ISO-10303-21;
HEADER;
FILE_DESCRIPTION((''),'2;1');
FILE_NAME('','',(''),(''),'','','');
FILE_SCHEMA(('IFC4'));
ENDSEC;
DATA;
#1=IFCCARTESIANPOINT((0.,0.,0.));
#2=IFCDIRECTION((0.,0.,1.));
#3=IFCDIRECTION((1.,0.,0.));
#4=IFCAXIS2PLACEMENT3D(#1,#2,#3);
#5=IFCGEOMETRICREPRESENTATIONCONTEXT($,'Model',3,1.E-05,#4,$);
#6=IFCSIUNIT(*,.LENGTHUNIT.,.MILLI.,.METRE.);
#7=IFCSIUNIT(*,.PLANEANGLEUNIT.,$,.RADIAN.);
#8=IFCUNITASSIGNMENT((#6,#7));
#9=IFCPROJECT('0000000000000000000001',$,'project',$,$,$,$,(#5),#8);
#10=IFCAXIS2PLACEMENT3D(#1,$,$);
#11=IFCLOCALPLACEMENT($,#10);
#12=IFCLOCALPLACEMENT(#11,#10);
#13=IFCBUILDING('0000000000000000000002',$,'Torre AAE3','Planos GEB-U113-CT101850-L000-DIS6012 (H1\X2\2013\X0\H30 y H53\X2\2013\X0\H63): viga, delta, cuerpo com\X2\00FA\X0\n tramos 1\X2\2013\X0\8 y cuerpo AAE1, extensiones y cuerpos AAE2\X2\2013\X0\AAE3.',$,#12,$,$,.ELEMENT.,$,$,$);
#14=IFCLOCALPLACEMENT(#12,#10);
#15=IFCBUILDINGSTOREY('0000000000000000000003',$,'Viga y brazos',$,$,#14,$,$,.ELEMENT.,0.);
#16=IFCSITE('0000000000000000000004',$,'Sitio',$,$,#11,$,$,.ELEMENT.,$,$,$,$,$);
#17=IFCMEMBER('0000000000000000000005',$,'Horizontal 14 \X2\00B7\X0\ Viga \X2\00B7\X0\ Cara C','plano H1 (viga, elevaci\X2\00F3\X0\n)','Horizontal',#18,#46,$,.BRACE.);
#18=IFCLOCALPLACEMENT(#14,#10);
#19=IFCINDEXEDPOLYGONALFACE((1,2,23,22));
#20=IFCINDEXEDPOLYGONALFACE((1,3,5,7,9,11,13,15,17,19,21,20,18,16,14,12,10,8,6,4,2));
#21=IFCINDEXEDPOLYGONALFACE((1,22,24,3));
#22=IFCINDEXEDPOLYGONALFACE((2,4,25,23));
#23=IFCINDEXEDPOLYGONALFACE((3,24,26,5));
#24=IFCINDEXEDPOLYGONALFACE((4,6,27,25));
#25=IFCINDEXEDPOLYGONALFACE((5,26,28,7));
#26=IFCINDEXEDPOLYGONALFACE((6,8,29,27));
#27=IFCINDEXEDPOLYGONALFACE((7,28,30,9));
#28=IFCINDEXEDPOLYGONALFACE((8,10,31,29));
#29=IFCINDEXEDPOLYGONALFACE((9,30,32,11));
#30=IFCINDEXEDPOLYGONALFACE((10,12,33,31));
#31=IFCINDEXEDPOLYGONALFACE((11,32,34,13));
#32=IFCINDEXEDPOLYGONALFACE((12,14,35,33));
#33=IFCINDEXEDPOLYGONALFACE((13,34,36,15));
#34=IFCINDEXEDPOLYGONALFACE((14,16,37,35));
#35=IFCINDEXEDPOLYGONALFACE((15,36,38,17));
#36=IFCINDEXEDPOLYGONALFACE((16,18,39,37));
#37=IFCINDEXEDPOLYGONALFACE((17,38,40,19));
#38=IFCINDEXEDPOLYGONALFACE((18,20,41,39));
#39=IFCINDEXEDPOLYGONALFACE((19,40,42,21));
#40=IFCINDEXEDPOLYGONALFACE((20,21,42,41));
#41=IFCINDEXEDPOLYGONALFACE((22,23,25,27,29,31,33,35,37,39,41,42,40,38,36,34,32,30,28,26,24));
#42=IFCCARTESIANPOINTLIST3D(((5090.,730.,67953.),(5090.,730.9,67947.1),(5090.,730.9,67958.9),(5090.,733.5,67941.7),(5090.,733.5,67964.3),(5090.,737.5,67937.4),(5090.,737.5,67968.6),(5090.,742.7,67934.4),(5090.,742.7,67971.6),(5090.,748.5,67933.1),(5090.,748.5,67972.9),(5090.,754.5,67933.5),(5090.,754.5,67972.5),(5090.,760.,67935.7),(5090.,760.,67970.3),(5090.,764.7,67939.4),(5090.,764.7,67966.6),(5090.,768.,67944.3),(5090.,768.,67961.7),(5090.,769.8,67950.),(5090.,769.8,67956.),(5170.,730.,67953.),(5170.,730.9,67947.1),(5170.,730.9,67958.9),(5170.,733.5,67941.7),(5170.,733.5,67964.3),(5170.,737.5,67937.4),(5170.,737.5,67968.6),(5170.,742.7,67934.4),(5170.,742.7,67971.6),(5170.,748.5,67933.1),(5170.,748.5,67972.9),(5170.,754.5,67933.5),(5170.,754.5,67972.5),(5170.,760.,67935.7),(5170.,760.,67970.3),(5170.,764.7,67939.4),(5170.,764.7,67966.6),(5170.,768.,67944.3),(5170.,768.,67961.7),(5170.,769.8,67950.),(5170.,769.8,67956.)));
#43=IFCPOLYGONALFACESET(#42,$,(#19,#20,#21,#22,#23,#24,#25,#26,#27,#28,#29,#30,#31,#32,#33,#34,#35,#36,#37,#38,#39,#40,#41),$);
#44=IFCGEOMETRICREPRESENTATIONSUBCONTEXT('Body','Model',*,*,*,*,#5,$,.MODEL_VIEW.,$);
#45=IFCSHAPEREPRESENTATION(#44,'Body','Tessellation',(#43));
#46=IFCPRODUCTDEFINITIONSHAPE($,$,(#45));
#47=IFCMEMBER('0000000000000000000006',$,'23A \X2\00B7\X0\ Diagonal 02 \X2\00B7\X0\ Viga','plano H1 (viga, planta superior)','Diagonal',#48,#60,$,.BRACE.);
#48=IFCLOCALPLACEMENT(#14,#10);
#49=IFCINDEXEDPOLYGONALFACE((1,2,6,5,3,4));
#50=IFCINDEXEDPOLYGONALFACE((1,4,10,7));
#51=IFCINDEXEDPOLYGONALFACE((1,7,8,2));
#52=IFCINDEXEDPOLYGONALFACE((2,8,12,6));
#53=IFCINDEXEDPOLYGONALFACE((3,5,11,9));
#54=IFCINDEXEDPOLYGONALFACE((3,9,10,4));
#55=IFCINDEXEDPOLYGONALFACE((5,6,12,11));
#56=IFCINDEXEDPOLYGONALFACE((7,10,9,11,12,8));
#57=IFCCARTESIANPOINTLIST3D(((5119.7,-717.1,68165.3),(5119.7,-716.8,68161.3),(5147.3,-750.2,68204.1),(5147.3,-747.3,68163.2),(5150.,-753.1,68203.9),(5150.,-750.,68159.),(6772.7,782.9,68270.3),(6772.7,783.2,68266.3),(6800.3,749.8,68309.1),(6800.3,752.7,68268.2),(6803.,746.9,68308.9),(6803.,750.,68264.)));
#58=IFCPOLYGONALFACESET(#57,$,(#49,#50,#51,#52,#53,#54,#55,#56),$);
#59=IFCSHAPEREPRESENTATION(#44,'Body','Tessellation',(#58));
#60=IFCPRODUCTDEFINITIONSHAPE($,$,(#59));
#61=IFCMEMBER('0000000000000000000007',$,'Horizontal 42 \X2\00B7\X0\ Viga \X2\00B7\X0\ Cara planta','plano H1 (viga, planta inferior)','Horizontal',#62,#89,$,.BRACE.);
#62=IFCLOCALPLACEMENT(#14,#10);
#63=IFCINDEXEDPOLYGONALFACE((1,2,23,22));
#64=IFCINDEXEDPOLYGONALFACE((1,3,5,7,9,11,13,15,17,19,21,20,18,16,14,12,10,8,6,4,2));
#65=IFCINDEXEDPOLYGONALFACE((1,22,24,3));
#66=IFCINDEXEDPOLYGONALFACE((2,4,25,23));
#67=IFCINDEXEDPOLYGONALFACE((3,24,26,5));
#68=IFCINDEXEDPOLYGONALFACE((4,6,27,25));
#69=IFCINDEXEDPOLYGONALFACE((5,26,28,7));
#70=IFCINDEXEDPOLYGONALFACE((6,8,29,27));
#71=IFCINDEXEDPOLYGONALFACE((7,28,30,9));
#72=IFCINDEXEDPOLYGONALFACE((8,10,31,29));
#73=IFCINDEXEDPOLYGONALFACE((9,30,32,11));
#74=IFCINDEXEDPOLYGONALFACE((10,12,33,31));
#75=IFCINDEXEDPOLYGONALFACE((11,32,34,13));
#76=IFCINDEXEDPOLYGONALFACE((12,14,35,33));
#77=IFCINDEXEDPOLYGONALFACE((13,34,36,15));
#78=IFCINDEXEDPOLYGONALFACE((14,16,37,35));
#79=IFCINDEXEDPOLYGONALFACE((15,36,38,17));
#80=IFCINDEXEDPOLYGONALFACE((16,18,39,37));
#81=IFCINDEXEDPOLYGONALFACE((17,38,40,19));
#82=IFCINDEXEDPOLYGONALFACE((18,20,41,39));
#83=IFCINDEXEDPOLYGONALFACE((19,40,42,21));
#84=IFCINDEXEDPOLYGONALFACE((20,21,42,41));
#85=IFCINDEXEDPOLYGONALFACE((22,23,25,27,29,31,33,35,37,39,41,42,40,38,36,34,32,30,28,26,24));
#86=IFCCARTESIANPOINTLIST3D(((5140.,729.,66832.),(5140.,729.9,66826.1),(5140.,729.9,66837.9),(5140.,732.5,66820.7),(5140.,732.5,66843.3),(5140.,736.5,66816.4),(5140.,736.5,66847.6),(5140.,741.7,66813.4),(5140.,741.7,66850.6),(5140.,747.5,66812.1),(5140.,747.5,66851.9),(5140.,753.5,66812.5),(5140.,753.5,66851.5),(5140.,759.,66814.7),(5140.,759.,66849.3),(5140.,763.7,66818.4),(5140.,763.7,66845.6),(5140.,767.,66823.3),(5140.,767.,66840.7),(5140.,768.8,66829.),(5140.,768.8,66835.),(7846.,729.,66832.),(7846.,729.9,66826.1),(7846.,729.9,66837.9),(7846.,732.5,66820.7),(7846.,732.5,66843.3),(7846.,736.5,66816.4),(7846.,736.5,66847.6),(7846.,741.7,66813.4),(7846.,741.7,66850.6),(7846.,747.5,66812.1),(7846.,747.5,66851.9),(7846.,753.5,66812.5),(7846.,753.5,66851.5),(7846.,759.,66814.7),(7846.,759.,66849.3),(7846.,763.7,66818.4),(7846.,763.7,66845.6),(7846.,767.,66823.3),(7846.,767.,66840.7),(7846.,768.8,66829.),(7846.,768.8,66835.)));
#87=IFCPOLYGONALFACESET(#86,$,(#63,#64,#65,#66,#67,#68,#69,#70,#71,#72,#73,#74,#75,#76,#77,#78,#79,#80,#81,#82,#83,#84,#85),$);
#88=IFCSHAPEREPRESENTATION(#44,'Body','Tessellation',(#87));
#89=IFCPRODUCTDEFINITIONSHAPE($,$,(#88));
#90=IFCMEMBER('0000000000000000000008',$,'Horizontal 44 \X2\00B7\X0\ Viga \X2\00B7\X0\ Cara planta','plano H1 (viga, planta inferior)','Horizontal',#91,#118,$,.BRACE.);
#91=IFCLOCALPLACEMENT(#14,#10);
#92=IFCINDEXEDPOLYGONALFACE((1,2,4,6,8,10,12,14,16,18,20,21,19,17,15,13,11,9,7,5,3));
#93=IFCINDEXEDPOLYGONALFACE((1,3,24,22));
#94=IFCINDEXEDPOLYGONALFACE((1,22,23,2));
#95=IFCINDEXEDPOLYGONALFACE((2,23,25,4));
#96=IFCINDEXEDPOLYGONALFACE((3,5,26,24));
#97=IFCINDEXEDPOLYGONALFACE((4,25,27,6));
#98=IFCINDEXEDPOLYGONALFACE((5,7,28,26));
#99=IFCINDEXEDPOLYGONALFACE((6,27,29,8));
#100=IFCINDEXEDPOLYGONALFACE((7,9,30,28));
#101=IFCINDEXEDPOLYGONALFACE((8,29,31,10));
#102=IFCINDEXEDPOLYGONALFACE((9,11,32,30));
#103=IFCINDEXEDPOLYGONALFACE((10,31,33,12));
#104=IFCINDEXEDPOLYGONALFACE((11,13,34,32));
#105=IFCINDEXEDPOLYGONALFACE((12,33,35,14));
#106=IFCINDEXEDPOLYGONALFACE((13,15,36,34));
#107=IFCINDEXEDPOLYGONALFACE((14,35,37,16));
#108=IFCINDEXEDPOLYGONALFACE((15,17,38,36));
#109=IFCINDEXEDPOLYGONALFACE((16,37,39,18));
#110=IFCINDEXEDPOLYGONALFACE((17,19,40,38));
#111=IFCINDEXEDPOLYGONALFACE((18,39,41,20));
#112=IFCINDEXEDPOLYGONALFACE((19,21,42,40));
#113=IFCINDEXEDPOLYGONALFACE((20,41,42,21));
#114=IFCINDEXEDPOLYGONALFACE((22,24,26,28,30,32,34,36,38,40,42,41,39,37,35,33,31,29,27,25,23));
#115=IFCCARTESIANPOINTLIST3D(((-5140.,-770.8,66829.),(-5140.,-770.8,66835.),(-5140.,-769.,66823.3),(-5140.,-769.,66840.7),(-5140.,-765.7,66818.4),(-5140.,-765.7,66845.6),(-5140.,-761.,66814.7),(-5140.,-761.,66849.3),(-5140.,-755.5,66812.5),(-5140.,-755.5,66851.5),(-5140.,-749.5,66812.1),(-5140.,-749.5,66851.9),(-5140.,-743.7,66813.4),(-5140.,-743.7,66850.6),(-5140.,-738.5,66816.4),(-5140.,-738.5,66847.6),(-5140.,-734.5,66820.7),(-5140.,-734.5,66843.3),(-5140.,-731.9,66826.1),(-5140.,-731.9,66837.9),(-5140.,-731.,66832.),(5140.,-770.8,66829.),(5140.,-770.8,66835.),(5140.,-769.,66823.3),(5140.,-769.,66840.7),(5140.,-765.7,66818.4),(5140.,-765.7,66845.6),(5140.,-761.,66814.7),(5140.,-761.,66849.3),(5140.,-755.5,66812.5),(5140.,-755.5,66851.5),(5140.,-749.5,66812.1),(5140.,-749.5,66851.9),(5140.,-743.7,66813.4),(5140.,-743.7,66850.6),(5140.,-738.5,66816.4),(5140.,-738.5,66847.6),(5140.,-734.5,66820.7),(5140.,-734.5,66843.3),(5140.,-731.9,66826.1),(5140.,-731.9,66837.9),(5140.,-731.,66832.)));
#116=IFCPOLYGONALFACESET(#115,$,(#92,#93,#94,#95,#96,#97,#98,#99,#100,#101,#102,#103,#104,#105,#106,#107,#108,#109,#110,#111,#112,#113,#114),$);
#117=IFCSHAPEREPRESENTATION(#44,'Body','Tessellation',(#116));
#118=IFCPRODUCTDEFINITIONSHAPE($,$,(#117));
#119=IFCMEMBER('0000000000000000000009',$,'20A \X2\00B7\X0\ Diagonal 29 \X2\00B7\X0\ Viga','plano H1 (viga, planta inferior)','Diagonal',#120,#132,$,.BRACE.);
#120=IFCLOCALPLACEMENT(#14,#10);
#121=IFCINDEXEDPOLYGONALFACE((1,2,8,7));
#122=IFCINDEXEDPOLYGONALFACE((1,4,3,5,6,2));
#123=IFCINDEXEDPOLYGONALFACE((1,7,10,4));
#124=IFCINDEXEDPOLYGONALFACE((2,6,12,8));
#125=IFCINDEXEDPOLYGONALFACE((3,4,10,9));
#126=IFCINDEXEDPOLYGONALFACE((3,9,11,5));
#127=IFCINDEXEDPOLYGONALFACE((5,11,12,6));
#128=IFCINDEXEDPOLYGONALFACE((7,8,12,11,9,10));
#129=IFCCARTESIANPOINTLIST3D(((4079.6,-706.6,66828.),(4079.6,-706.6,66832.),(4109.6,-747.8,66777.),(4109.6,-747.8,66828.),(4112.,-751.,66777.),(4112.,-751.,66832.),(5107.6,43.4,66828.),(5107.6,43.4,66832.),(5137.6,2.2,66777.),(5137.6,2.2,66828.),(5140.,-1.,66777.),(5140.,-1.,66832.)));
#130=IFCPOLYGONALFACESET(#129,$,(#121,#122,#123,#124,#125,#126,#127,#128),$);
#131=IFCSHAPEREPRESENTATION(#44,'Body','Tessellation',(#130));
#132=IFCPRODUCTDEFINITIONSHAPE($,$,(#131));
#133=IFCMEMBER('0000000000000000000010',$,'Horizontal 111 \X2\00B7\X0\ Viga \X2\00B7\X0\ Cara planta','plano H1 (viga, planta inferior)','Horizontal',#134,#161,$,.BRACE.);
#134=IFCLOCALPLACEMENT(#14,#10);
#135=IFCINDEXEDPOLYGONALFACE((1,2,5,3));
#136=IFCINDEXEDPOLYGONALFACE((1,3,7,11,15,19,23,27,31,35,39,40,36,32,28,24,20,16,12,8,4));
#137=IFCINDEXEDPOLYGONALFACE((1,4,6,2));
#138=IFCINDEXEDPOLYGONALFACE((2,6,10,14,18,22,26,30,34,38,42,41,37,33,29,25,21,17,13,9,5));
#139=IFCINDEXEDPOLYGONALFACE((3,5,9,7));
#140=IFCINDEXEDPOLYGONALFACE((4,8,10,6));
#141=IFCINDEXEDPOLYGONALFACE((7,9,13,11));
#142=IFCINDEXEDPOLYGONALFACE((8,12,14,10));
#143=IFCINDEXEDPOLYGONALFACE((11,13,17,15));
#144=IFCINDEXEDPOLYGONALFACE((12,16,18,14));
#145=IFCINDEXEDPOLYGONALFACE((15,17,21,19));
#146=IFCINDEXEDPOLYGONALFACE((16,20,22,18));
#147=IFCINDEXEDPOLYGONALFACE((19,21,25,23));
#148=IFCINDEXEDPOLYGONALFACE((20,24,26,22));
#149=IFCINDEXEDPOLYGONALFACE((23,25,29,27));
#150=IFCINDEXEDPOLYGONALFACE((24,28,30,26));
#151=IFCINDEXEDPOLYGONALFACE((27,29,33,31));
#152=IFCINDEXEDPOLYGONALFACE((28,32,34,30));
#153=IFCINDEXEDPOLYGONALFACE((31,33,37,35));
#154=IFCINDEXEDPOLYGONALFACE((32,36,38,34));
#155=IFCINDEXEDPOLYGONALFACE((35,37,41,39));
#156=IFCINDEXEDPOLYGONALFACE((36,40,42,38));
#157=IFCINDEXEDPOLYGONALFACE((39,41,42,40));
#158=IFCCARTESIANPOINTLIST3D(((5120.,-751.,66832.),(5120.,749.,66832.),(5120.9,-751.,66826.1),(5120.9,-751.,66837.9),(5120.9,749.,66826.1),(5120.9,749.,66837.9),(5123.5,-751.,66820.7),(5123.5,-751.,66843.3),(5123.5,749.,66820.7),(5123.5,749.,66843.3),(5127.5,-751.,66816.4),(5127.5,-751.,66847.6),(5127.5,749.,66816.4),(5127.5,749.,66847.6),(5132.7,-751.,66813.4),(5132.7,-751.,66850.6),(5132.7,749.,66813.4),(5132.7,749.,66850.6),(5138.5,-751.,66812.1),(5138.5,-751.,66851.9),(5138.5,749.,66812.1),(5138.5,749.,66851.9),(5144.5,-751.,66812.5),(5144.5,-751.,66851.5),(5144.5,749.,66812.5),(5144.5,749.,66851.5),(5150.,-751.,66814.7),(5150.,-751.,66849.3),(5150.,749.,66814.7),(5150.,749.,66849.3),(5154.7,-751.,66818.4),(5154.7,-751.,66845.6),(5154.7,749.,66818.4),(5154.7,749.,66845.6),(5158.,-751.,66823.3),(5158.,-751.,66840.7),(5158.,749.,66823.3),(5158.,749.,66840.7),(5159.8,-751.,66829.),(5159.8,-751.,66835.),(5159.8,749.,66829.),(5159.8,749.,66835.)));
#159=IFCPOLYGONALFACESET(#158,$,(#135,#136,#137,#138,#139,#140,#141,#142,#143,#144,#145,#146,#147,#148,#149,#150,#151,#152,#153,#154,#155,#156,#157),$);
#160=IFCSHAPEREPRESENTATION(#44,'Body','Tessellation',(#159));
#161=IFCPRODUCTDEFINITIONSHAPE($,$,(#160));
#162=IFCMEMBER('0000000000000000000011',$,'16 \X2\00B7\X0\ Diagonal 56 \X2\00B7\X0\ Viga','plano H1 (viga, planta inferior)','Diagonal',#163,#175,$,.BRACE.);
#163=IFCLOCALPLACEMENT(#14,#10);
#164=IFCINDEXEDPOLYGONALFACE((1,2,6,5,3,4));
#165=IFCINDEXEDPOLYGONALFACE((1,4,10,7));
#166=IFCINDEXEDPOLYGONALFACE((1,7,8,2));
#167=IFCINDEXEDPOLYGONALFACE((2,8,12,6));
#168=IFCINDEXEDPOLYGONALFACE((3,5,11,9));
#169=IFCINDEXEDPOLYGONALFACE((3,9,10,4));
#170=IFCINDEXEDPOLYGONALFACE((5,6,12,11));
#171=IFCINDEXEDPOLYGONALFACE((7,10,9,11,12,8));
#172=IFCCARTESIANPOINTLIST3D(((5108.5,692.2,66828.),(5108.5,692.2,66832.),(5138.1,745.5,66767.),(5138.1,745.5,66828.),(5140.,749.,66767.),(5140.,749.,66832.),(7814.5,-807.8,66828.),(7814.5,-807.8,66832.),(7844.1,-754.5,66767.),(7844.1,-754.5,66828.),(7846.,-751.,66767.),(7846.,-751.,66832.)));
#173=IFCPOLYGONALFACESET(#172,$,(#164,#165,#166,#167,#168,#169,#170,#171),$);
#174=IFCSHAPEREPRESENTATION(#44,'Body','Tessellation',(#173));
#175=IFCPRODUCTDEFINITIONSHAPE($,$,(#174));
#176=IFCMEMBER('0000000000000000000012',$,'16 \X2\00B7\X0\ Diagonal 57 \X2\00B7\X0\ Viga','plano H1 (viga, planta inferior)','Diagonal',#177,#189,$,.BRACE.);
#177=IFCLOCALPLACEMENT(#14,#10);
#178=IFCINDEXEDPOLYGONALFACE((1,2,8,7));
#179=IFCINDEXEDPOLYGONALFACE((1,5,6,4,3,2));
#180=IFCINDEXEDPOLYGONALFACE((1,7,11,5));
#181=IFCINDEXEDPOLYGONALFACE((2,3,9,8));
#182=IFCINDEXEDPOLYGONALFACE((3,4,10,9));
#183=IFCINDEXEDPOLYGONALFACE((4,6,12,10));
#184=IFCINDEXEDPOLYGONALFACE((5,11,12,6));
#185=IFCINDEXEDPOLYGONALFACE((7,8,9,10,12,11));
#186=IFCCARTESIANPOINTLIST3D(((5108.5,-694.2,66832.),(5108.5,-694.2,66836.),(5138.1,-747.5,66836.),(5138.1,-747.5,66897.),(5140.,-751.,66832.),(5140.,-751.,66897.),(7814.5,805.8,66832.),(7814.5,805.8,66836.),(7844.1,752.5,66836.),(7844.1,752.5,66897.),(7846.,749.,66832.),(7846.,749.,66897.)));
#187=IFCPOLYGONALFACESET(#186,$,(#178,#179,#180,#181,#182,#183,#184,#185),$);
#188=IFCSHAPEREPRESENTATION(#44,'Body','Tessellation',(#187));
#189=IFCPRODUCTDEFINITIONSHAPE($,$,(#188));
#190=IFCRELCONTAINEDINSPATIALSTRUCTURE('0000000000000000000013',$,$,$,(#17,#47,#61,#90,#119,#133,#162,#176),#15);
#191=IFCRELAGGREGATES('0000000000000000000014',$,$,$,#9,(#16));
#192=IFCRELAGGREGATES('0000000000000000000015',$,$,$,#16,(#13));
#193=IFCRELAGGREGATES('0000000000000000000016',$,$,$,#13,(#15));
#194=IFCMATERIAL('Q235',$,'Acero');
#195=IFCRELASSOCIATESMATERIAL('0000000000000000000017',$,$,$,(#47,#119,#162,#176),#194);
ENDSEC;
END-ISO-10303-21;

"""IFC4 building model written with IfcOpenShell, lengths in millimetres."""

from ifc_helpers import new_model, si_unit, frame, frame_2d, origin, origin_with_axes, place, context, subcontext, project, spatial, circle, l_section, extrude, material, element, save


model = new_model("IFC4")

# Units and contexts
model_context = context("Model", 3, precision=1e-05, world=origin_with_axes())
body_context = subcontext(model_context, "Body", "Model", "MODEL_VIEW")
ifc_project = project(units=[si_unit("LENGTHUNIT", "METRE", prefix="MILLI"), si_unit("PLANEANGLEUNIT", "RADIAN")], contexts=[model_context])

# Site, building, storey
site_placement = place(None, origin())
site = spatial("IfcSite", under=ifc_project, at=site_placement, Name="Sitio", CompositionType="ELEMENT")
building_placement = place(site_placement, origin())
building = spatial("IfcBuilding", under=site, at=building_placement, Name="Torre AAE3", Description="Planos GEB-U113-CT101850-L000-DIS6012 (H1–H30 y H53–H63): viga, delta, cuerpo común tramos 1–8 y cuerpo AAE1, extensiones y cuerpos AAE2–AAE3.", CompositionType="ELEMENT")
storey_placement = place(building_placement, origin())
storey = spatial("IfcBuildingStorey", under=building, at=storey_placement, Name="Viga y brazos", CompositionType="ELEMENT", Elevation=0.0)

# Members
for number, where, z_axis, x_axis, name in (
    (1, (5090.0, 750.0, 67953.0), (1.0, 0.0, 0.0), (0.0, -1.0, 0.0), "Horizontal 14 · Viga · Cara C"),
):
    element("IfcMember", number, at=place(storey_placement, frame(where, z_axis=z_axis, x_axis=x_axis)), inside=storey, Name=name, Description="plano H1 (viga, elevación)", ObjectType="Horizontal", PredefinedType="BRACE", context=body_context, shape_type="SweptSolid", body=[
        extrude(circle(Radius=20.0), None, (0.0, 0.0, 1.0), 80.0),
    ])
ifc_material = material(Name="Q235", Category="Acero")
member_1_placement = place(storey_placement, frame((5150.0, -750.0, 68159.0), z_axis=(0.73973, 0.671261, 0.046988), x_axis=(-0.672904, 0.737924, 0.051655)))
element("IfcMember", 2, at=member_1_placement, inside=storey, material=ifc_material, Name="23A · Diagonal 02 · Viga", Description="plano H1 (viga, planta superior)", ObjectType="Diagonal", PredefinedType="BRACE", context=body_context, shape_type="SweptSolid", body=[
    extrude(l_section(Depth=45.0, Width=45.0, Thickness=4.0, at=frame_2d((22.5, 22.5))), None, (0.0, 0.0, 1.0), 2234.6),
])
member_2_placement = place(storey_placement, frame((5140.0, 749.0, 66832.0), z_axis=(1.0, 0.0, 0.0), x_axis=(0.0, -1.0, 0.0)))
element("IfcMember", 3, at=member_2_placement, inside=storey, Name="Horizontal 42 · Viga · Cara planta", Description="plano H1 (viga, planta inferior)", ObjectType="Horizontal", PredefinedType="BRACE", context=body_context, shape_type="SweptSolid", body=[
    extrude(circle(Radius=20.0), None, (0.0, 0.0, 1.0), 2706.0),
])
member_3_placement = place(storey_placement, frame((5140.0, -751.0, 66832.0), z_axis=(-1.0, 0.0, 0.0), x_axis=(0.0, 1.0, 0.0)))
element("IfcMember", 4, at=member_3_placement, inside=storey, Name="Horizontal 44 · Viga · Cara planta", Description="plano H1 (viga, planta inferior)", ObjectType="Horizontal", PredefinedType="BRACE", context=body_context, shape_type="SweptSolid", body=[
    extrude(circle(Radius=20.0), None, (0.0, 0.0, 1.0), 10280.0),
])
member_4_placement = place(storey_placement, frame((5140.0, -1.0, 66832.0), z_axis=(-0.807852, -0.589386, 0.0), x_axis=(-0.589386, 0.807852, 0.0)))
element("IfcMember", 5, at=member_4_placement, inside=storey, material=ifc_material, Name="20A · Diagonal 29 · Viga", Description="plano H1 (viga, planta inferior)", ObjectType="Diagonal", PredefinedType="BRACE", context=body_context, shape_type="SweptSolid", body=[
    extrude(l_section(Depth=55.0, Width=55.0, Thickness=4.0, at=frame_2d((27.5, 27.5))), None, (0.0, 0.0, 1.0), 1272.5),
])
member_5_placement = place(storey_placement, frame((5140.0, 749.0, 66832.0), z_axis=(0.0, -1.0, 0.0), x_axis=(-1.0, 0.0, 0.0)))
element("IfcMember", 6, at=member_5_placement, inside=storey, Name="Horizontal 111 · Viga · Cara planta", Description="plano H1 (viga, planta inferior)", ObjectType="Horizontal", PredefinedType="BRACE", context=body_context, shape_type="SweptSolid", body=[
    extrude(circle(Radius=20.0), None, (0.0, 0.0, 1.0), 1500.0),
])
for number, where, z_axis, x_axis, name in (
    (7, (5140.0, 749.0, 66832.0), (0.874614, -0.484819, 0.0), (-0.484819, -0.874614, 0.0), "16 · Diagonal 56 · Viga"),
    (8, (5140.0, -751.0, 66832.0), (0.874614, 0.484819, 0.0), (-0.484819, 0.874614, 0.0), "16 · Diagonal 57 · Viga"),
):
    element("IfcMember", number, at=place(storey_placement, frame(where, z_axis=z_axis, x_axis=x_axis)), inside=storey, material=ifc_material, Name=name, Description="plano H1 (viga, planta inferior)", ObjectType="Diagonal", PredefinedType="BRACE", context=body_context, shape_type="SweptSolid", body=[
        extrude(l_section(Depth=65.0, Width=65.0, Thickness=4.0, at=frame_2d((32.5, 32.5))), None, (0.0, 0.0, 1.0), 3093.9),
    ])

save(model, "model.ifc")
